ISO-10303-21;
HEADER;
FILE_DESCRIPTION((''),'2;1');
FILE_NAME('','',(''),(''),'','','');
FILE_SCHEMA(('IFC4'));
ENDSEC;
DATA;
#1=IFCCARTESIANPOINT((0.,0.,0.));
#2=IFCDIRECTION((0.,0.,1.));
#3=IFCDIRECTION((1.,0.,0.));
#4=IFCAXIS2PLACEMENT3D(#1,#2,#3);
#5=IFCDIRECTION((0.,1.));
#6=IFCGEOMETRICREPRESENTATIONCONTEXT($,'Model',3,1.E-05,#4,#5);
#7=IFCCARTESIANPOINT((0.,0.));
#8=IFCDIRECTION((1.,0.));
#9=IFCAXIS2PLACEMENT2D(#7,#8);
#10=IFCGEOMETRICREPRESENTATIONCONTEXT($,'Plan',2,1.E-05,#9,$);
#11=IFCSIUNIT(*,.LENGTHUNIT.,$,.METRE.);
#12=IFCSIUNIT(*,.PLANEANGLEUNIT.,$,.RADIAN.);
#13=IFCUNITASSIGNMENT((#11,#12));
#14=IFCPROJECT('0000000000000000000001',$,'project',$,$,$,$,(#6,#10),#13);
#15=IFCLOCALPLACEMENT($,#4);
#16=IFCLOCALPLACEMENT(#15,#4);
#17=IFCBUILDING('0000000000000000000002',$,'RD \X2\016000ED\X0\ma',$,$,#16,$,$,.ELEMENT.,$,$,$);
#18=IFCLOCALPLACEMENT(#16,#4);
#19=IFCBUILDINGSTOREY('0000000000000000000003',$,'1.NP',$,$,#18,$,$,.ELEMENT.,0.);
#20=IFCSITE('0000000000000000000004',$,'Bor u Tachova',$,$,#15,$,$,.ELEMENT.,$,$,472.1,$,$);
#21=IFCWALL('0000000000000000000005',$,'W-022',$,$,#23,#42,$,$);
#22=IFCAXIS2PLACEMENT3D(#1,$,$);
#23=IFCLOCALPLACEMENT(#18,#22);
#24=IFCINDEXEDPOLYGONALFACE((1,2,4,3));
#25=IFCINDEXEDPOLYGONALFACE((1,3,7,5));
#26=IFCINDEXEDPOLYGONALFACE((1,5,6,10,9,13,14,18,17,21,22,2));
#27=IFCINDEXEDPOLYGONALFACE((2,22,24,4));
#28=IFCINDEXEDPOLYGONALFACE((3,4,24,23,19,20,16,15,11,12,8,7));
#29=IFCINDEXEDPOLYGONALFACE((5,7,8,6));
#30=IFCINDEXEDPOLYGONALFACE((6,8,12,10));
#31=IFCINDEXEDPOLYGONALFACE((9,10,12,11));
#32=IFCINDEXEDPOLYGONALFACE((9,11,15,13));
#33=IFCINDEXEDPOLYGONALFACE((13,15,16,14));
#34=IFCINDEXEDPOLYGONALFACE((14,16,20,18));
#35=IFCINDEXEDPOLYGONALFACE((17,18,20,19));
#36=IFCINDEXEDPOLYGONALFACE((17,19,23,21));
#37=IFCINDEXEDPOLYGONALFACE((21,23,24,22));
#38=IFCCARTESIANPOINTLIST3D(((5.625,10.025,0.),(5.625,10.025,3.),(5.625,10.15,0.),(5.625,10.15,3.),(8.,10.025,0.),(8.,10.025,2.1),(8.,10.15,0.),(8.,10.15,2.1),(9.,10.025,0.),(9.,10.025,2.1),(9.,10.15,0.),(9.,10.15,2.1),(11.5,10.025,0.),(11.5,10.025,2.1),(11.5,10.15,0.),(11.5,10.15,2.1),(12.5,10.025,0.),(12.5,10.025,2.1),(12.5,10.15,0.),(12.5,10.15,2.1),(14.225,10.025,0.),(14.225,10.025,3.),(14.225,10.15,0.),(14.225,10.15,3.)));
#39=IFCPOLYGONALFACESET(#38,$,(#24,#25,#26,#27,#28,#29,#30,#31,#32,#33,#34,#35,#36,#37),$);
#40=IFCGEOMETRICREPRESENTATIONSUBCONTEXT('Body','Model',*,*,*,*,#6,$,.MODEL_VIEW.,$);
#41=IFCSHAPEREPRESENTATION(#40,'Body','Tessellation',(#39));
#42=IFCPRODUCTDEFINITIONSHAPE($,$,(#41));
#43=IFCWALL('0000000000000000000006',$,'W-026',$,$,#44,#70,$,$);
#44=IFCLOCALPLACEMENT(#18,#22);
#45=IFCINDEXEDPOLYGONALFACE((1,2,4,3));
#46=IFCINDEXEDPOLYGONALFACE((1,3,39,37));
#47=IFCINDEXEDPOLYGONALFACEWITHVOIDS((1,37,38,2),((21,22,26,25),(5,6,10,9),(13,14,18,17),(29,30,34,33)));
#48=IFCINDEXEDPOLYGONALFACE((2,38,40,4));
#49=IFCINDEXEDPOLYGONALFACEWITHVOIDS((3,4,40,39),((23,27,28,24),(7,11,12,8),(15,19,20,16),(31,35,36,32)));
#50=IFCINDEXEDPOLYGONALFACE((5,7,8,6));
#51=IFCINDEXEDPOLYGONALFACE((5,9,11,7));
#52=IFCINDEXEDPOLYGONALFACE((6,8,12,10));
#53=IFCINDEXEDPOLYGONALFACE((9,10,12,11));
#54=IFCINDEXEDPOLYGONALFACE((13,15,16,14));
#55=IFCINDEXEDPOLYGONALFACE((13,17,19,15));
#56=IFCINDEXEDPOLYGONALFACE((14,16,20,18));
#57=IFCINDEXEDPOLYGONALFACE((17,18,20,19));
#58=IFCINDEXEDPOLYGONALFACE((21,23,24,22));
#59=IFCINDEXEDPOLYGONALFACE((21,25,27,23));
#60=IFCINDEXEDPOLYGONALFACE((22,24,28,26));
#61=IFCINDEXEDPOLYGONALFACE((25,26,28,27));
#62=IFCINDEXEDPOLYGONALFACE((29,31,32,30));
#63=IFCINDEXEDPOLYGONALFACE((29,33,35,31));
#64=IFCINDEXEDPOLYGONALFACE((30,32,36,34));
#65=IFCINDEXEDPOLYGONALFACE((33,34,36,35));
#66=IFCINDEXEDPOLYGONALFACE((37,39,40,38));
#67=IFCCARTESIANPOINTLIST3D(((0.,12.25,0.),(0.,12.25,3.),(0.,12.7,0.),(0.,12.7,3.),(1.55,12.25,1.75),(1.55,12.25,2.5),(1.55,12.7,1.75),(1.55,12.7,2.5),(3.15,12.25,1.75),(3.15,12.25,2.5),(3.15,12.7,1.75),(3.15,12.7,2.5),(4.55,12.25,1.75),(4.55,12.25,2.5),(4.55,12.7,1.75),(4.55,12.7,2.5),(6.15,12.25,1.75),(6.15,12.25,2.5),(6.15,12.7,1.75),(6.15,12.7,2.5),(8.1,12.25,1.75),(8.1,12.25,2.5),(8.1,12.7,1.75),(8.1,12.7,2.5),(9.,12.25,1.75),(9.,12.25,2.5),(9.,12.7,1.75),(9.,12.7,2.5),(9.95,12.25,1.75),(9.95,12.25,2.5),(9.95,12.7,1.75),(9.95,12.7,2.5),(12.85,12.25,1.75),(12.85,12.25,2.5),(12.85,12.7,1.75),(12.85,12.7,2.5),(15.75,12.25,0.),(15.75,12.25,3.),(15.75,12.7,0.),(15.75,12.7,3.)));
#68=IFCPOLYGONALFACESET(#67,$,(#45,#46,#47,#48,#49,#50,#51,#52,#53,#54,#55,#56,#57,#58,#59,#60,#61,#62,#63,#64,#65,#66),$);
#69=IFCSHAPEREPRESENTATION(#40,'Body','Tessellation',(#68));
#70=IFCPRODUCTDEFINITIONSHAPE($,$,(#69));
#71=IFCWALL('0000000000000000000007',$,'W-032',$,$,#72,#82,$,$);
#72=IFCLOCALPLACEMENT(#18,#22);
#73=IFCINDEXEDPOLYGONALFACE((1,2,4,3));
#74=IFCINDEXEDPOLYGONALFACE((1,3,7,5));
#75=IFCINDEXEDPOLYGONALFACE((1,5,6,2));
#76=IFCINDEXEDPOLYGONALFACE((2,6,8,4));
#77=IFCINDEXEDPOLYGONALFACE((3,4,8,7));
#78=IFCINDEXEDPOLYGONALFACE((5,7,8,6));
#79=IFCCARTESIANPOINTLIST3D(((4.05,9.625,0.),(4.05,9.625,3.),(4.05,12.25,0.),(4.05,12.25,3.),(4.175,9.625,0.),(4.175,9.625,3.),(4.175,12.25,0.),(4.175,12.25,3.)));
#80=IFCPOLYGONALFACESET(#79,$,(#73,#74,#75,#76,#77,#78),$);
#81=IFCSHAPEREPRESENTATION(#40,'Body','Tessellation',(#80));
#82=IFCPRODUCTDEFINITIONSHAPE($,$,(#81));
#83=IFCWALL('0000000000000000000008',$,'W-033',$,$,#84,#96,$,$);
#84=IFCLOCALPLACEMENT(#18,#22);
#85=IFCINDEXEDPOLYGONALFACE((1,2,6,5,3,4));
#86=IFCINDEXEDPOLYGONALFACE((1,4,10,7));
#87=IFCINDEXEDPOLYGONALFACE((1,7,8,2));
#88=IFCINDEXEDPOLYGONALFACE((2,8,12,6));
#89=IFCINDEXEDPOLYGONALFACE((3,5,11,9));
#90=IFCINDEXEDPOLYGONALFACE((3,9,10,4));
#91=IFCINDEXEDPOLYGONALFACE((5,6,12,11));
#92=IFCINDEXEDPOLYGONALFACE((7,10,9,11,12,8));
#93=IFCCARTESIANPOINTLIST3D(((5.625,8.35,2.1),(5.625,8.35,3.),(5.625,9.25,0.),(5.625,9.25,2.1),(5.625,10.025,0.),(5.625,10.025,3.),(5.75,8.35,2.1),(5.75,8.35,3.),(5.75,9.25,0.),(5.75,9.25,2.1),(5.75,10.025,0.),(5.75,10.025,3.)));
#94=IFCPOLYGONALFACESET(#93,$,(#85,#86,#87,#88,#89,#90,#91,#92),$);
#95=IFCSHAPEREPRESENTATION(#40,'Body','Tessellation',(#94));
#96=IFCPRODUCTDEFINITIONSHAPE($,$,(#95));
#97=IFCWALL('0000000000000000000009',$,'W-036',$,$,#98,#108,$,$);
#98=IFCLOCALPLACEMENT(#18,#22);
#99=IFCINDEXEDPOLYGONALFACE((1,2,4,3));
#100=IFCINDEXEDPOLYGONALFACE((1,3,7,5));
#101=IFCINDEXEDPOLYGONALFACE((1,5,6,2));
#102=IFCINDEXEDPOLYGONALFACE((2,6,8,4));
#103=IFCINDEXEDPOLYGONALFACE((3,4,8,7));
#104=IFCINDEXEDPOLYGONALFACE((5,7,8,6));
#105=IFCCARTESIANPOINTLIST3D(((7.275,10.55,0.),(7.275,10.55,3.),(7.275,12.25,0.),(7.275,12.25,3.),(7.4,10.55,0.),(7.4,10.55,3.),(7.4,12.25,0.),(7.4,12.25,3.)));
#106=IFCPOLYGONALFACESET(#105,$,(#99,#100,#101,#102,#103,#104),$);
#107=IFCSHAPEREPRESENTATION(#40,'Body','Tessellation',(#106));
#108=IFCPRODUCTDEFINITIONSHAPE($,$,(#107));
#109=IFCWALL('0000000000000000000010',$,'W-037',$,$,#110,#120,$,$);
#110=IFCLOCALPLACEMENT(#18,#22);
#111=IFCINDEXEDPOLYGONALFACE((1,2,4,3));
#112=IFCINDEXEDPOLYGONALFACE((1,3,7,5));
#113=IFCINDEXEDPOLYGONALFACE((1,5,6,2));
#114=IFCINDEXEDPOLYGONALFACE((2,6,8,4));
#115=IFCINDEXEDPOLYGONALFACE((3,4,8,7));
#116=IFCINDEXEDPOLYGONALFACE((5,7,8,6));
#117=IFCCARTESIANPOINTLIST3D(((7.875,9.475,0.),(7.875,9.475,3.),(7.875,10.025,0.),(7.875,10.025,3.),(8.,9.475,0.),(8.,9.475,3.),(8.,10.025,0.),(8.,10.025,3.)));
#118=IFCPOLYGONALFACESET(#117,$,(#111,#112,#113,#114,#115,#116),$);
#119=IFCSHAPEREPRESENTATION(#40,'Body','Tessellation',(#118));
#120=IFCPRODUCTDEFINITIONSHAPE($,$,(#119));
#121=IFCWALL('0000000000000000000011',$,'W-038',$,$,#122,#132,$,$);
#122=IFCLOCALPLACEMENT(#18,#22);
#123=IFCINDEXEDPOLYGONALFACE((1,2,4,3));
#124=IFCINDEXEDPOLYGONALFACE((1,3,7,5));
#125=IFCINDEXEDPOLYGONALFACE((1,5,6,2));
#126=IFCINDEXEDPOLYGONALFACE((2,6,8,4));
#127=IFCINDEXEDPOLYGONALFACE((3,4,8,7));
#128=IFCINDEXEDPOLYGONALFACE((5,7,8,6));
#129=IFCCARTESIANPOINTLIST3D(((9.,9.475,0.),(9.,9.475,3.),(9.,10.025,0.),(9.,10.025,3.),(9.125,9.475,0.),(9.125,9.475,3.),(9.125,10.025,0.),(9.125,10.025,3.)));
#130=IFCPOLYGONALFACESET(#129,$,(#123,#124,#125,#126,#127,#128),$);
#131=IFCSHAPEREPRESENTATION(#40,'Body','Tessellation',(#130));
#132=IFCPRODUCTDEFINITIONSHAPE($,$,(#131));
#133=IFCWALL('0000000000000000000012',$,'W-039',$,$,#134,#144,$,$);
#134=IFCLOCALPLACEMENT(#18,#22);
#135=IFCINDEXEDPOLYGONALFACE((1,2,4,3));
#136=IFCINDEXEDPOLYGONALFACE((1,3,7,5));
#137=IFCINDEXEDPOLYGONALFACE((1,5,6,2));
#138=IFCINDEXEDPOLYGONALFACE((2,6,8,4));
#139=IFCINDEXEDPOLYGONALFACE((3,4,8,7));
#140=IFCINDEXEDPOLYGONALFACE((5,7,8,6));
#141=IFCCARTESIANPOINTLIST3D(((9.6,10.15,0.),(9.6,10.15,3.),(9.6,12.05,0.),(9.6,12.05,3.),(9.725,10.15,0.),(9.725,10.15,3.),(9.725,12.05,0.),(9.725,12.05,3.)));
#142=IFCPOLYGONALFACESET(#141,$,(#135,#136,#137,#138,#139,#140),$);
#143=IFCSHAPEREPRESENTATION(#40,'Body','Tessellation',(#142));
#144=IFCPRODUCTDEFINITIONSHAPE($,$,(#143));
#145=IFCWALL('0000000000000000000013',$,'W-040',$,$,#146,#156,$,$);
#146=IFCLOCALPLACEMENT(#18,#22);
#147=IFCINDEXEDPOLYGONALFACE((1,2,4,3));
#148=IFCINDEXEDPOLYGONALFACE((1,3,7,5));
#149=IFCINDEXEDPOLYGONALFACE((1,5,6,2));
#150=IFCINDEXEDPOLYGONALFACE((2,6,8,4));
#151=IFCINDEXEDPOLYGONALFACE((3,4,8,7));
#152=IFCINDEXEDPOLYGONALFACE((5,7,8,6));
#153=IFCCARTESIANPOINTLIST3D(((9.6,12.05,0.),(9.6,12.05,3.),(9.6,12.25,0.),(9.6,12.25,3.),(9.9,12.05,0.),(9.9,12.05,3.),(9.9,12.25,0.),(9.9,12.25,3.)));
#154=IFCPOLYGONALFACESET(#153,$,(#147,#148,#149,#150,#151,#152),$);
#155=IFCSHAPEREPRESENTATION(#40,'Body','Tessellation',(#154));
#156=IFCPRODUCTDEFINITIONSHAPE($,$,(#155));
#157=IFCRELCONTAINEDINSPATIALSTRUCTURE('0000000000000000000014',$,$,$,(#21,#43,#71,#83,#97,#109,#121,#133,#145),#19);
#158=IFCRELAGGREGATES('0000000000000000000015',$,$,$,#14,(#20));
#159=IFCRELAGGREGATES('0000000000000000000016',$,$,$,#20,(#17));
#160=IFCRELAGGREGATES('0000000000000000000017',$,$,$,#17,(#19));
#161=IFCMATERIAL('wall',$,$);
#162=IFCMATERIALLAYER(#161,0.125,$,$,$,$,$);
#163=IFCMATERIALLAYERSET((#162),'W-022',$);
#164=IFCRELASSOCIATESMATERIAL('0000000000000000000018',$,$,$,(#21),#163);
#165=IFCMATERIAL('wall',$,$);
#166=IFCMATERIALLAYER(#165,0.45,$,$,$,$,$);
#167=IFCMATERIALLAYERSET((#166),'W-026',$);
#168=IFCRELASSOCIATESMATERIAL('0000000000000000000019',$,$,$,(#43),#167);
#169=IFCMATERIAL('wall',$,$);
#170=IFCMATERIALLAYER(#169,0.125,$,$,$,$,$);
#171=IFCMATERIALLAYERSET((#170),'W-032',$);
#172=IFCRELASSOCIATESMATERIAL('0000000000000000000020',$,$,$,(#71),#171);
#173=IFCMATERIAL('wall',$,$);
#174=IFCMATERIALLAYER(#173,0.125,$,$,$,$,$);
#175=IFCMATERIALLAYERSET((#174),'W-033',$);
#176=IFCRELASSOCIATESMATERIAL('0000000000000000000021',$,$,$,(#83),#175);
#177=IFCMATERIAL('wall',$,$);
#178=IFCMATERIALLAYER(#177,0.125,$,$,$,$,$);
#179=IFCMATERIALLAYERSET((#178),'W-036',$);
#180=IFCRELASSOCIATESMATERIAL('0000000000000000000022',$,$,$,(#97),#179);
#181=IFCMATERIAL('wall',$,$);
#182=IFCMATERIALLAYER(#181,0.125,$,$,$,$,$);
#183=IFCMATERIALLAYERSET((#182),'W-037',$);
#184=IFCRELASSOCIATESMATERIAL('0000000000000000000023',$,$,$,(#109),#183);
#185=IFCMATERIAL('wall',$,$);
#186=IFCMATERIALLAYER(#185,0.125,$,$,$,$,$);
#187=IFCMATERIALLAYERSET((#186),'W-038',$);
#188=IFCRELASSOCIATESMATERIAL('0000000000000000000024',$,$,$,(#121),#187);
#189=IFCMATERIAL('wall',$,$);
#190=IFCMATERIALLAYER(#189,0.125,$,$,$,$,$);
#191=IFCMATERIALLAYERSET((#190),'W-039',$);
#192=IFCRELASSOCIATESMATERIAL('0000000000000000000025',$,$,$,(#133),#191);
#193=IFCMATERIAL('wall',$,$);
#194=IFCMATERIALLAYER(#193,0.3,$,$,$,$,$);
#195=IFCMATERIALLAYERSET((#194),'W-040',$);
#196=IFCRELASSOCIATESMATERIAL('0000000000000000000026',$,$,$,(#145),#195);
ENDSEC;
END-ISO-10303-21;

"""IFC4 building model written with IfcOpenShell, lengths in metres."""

from ifc_helpers import new_model, si_unit, direction, frame, frame_2d, origin_with_axes, origin_2d_with_axis, place, context, subcontext, project, spatial, line, indexed_curve, rectangle, outline, extrude, material, layer, layer_set, layer_usage, element, save


model = new_model("IFC4")

# Units and contexts
model_context = context("Model", 3, precision=1e-05, world=origin_with_axes(), true_north=direction((0.0, 1.0)))
plan_context = context("Plan", 2, precision=1e-05, world=origin_2d_with_axis())
body_context = subcontext(model_context, "Body", "Model", "MODEL_VIEW")
ifc_project = project(units=[si_unit("LENGTHUNIT", "METRE"), si_unit("PLANEANGLEUNIT", "RADIAN")], contexts=[model_context, plan_context])

# Site, building, storey
site_placement = place(None, origin_with_axes())
site = spatial("IfcSite", under=ifc_project, at=site_placement, Name="Bor u Tachova", CompositionType="ELEMENT", RefElevation=472.1)
building_placement = place(site_placement, origin_with_axes())
building = spatial("IfcBuilding", under=site, at=building_placement, Name="RD Šíma", CompositionType="ELEMENT")
storey_placement = place(building_placement, origin_with_axes())
storey = spatial("IfcBuildingStorey", under=building, at=storey_placement, Name="1.NP", CompositionType="ELEMENT", Elevation=0.0)

# Walls, openings
ifc_material_1 = material(Name="wall")
ifc_layer_1 = layer(ifc_material_1, 0.125)
ifc_layer_set_1 = layer_set([ifc_layer_1], Name="W-022")
ifc_layer_usage_1 = layer_usage(ifc_layer_set_1, "AXIS2", "POSITIVE", -0.0625)
wall_1_placement = place(storey_placement, frame((5.6875, 10.0875, 0.0), z_axis=(0.0, 0.0, 1.0), x_axis=(1.0, 0.0, 0.0)))
wall_1 = element("IfcWall", 1, at=wall_1_placement, inside=storey, material=ifc_layer_usage_1, Name="W-022", context=body_context, shape_type="SweptSolid", body=[
    extrude(outline(indexed_curve([(0.0625, -0.0625), (-0.0625, -0.0625), (-0.0625, 0.0625), (8.5375, 0.0625), (8.5375, -0.0625)], segments=[line(1, 2, 3, 4, 5, 1)])), origin_with_axes(), (0.0, 0.0, 1.0), 3.0),
])
opening_1_placement = place(wall_1_placement, frame((2.3125, 0.0, 0.0), z_axis=(0.0, 0.0, 1.0), x_axis=(1.0, 0.0, 0.0)))
element("IfcOpeningElement", 2, at=opening_1_placement, cuts=wall_1, PredefinedType="OPENING", context=body_context, shape_type="SweptSolid", body=[
    extrude(rectangle(XDim=1.0, YDim=0.125, at=frame_2d((0.5, 0.0))), origin_with_axes(), (0.0, 0.0, 1.0), 2.1),
])
opening_2_placement = place(wall_1_placement, frame((5.8125, 0.0, 0.0), z_axis=(0.0, 0.0, 1.0), x_axis=(1.0, 0.0, 0.0)))
element("IfcOpeningElement", 3, at=opening_2_placement, cuts=wall_1, PredefinedType="OPENING", context=body_context, shape_type="SweptSolid", body=[
    extrude(rectangle(XDim=1.0, YDim=0.125, at=frame_2d((0.5, 0.0))), origin_with_axes(), (0.0, 0.0, 1.0), 2.1),
])
ifc_material_2 = material(Name="wall")
ifc_layer_2 = layer(ifc_material_2, 0.45)
ifc_layer_set_2 = layer_set([ifc_layer_2], Name="W-026")
ifc_layer_usage_2 = layer_usage(ifc_layer_set_2, "AXIS2", "POSITIVE", -0.225)
wall_2_placement = place(storey_placement, frame((0.225, 12.475, 0.0), z_axis=(0.0, 0.0, 1.0), x_axis=(1.0, 0.0, 0.0)))
wall_2 = element("IfcWall", 4, at=wall_2_placement, inside=storey, material=ifc_layer_usage_2, Name="W-026", context=body_context, shape_type="SweptSolid", body=[
    extrude(outline(indexed_curve([(0.225, -0.225), (-0.225, -0.225), (-0.225, 0.225), (15.075, 0.225), (15.525, 0.225), (15.525, -0.225)], segments=[line(1, 2, 3, 4, 5, 6, 1)])), origin_with_axes(), (0.0, 0.0, 1.0), 3.0),
])
opening_3_placement = place(wall_2_placement, frame((1.325, 0.0, 1.75), z_axis=(0.0, 0.0, 1.0), x_axis=(1.0, 0.0, 0.0)))
element("IfcOpeningElement", 5, at=opening_3_placement, cuts=wall_2, PredefinedType="OPENING", context=body_context, shape_type="SweptSolid", body=[
    extrude(rectangle(XDim=1.6, YDim=0.45, at=frame_2d((0.8, 0.0))), origin_with_axes(), (0.0, 0.0, 1.0), 0.75),
])
opening_4_placement = place(wall_2_placement, frame((4.325, 0.0, 1.75), z_axis=(0.0, 0.0, 1.0), x_axis=(1.0, 0.0, 0.0)))
element("IfcOpeningElement", 6, at=opening_4_placement, cuts=wall_2, PredefinedType="OPENING", context=body_context, shape_type="SweptSolid", body=[
    extrude(rectangle(XDim=1.6, YDim=0.45, at=frame_2d((0.8, 0.0))), origin_with_axes(), (0.0, 0.0, 1.0), 0.75),
])
opening_5_placement = place(wall_2_placement, frame((7.875, 0.0, 1.75), z_axis=(0.0, 0.0, 1.0), x_axis=(1.0, 0.0, 0.0)))
element("IfcOpeningElement", 7, at=opening_5_placement, cuts=wall_2, PredefinedType="OPENING", context=body_context, shape_type="SweptSolid", body=[
    extrude(rectangle(XDim=0.9, YDim=0.45, at=frame_2d((0.45, 0.0))), origin_with_axes(), (0.0, 0.0, 1.0), 0.75),
])
opening_6_placement = place(wall_2_placement, frame((9.725, 0.0, 1.75), z_axis=(0.0, 0.0, 1.0), x_axis=(1.0, 0.0, 0.0)))
element("IfcOpeningElement", 8, at=opening_6_placement, cuts=wall_2, PredefinedType="OPENING", context=body_context, shape_type="SweptSolid", body=[
    extrude(rectangle(XDim=2.9, YDim=0.45, at=frame_2d((1.45, 0.0))), origin_with_axes(), (0.0, 0.0, 1.0), 0.75),
])

# Wall
ifc_material_3 = material(Name="wall")
ifc_layer_3 = layer(ifc_material_3, 0.125)
ifc_layer_set_3 = layer_set([ifc_layer_3], Name="W-032")
ifc_layer_usage_3 = layer_usage(ifc_layer_set_3, "AXIS2", "POSITIVE", -0.0625)
wall_3_placement = place(storey_placement, frame((4.1125, 9.5625, 0.0), z_axis=(0.0, 0.0, 1.0), x_axis=(0.0, 1.0, 0.0)))
element("IfcWall", 9, at=wall_3_placement, inside=storey, material=ifc_layer_usage_3, Name="W-032", context=body_context, shape_type="SweptSolid", body=[
    extrude(outline(indexed_curve([(0.0625, -0.0625), (0.0625, 0.0625), (2.6875, 0.0625), (2.6875, -0.0625)], segments=[line(1, 2, 3, 4, 1)])), origin_with_axes(), (0.0, 0.0, 1.0), 3.0),
])

# Wall, opening
ifc_material_4 = material(Name="wall")
ifc_layer_4 = layer(ifc_material_4, 0.125)
ifc_layer_set_4 = layer_set([ifc_layer_4], Name="W-033")
ifc_layer_usage_4 = layer_usage(ifc_layer_set_4, "AXIS2", "POSITIVE", -0.0625)
wall_4_placement = place(storey_placement, frame((5.6875, 8.35, 0.0), z_axis=(0.0, 0.0, 1.0), x_axis=(0.0, 1.0, 0.0)))
wall_4 = element("IfcWall", 10, at=wall_4_placement, inside=storey, material=ifc_layer_usage_4, Name="W-033", context=body_context, shape_type="SweptSolid", body=[
    extrude(outline(indexed_curve([(0.0, -0.0625), (0.0, 0.0625), (1.675, 0.0625), (1.675, -0.0625)], segments=[line(1, 2, 3, 4, 1)])), origin_with_axes(), (0.0, 0.0, 1.0), 3.0),
])
opening_7_placement = place(wall_4_placement, origin_with_axes())
element("IfcOpeningElement", 11, at=opening_7_placement, cuts=wall_4, PredefinedType="OPENING", context=body_context, shape_type="SweptSolid", body=[
    extrude(rectangle(XDim=0.9, YDim=0.125, at=frame_2d((0.45, 0.0))), origin_with_axes(), (0.0, 0.0, 1.0), 2.1),
])

# Walls
ifc_material_5 = material(Name="wall")
ifc_layer_5 = layer(ifc_material_5, 0.125)
ifc_layer_set_5 = layer_set([ifc_layer_5], Name="W-036")
ifc_layer_usage_5 = layer_usage(ifc_layer_set_5, "AXIS2", "POSITIVE", -0.0625)
wall_5_placement = place(storey_placement, frame((7.3375, 10.55, 0.0), z_axis=(0.0, 0.0, 1.0), x_axis=(0.0, 1.0, 0.0)))
element("IfcWall", 12, at=wall_5_placement, inside=storey, material=ifc_layer_usage_5, Name="W-036", context=body_context, shape_type="SweptSolid", body=[
    extrude(outline(indexed_curve([(0.0, -0.0625), (0.0, 0.0625), (1.7, 0.0625), (1.7, -0.0625)], segments=[line(1, 2, 3, 4, 1)])), origin_with_axes(), (0.0, 0.0, 1.0), 3.0),
])
ifc_material_6 = material(Name="wall")
ifc_layer_6 = layer(ifc_material_6, 0.125)
ifc_layer_set_6 = layer_set([ifc_layer_6], Name="W-037")
ifc_layer_usage_6 = layer_usage(ifc_layer_set_6, "AXIS2", "POSITIVE", -0.0625)
wall_6_placement = place(storey_placement, frame((7.9375, 9.475, 0.0), z_axis=(0.0, 0.0, 1.0), x_axis=(0.0, 1.0, 0.0)))
element("IfcWall", 13, at=wall_6_placement, inside=storey, material=ifc_layer_usage_6, Name="W-037", context=body_context, shape_type="SweptSolid", body=[
    extrude(outline(indexed_curve([(0.0, -0.0625), (0.0, 0.0625), (0.55, 0.0625), (0.55, -0.0625)], segments=[line(1, 2, 3, 4, 1)])), origin_with_axes(), (0.0, 0.0, 1.0), 3.0),
])
ifc_material_7 = material(Name="wall")
ifc_layer_7 = layer(ifc_material_7, 0.125)
ifc_layer_set_7 = layer_set([ifc_layer_7], Name="W-038")
ifc_layer_usage_7 = layer_usage(ifc_layer_set_7, "AXIS2", "POSITIVE", -0.0625)
wall_7_placement = place(storey_placement, frame((9.0625, 9.475, 0.0), z_axis=(0.0, 0.0, 1.0), x_axis=(0.0, 1.0, 0.0)))
element("IfcWall", 14, at=wall_7_placement, inside=storey, material=ifc_layer_usage_7, Name="W-038", context=body_context, shape_type="SweptSolid", body=[
    extrude(outline(indexed_curve([(0.0, -0.0625), (0.0, 0.0625), (0.55, 0.0625), (0.55, -0.0625)], segments=[line(1, 2, 3, 4, 1)])), origin_with_axes(), (0.0, 0.0, 1.0), 3.0),
])
ifc_material_8 = material(Name="wall")
ifc_layer_8 = layer(ifc_material_8, 0.125)
ifc_layer_set_8 = layer_set([ifc_layer_8], Name="W-039")
ifc_layer_usage_8 = layer_usage(ifc_layer_set_8, "AXIS2", "POSITIVE", -0.0625)
wall_8_placement = place(storey_placement, frame((9.6625, 10.0875, 0.0), z_axis=(0.0, 0.0, 1.0), x_axis=(0.0, 1.0, 0.0)))
element("IfcWall", 15, at=wall_8_placement, inside=storey, material=ifc_layer_usage_8, Name="W-039", context=body_context, shape_type="SweptSolid", body=[
    extrude(outline(indexed_curve([(0.0625, -0.0625), (0.0625, 0.0625), (1.9625, 0.0625), (1.9625, -0.0625)], segments=[line(1, 2, 3, 4, 1)])), origin_with_axes(), (0.0, 0.0, 1.0), 3.0),
])
ifc_material_9 = material(Name="wall")
ifc_layer_9 = layer(ifc_material_9, 0.3)
ifc_layer_set_9 = layer_set([ifc_layer_9], Name="W-040")
ifc_layer_usage_9 = layer_usage(ifc_layer_set_9, "AXIS2", "POSITIVE", -0.15)
wall_9_placement = place(storey_placement, frame((9.75, 12.05, 0.0), z_axis=(0.0, 0.0, 1.0), x_axis=(0.0, 1.0, 0.0)))
element("IfcWall", 16, at=wall_9_placement, inside=storey, material=ifc_layer_usage_9, Name="W-040", context=body_context, shape_type="SweptSolid", body=[
    extrude(outline(indexed_curve([(0.0, -0.15), (0.0, 0.15), (0.2, 0.15), (0.2, -0.15)], segments=[line(1, 2, 3, 4, 1)])), origin_with_axes(), (0.0, 0.0, 1.0), 3.0),
])

save(model, "model.ifc")
